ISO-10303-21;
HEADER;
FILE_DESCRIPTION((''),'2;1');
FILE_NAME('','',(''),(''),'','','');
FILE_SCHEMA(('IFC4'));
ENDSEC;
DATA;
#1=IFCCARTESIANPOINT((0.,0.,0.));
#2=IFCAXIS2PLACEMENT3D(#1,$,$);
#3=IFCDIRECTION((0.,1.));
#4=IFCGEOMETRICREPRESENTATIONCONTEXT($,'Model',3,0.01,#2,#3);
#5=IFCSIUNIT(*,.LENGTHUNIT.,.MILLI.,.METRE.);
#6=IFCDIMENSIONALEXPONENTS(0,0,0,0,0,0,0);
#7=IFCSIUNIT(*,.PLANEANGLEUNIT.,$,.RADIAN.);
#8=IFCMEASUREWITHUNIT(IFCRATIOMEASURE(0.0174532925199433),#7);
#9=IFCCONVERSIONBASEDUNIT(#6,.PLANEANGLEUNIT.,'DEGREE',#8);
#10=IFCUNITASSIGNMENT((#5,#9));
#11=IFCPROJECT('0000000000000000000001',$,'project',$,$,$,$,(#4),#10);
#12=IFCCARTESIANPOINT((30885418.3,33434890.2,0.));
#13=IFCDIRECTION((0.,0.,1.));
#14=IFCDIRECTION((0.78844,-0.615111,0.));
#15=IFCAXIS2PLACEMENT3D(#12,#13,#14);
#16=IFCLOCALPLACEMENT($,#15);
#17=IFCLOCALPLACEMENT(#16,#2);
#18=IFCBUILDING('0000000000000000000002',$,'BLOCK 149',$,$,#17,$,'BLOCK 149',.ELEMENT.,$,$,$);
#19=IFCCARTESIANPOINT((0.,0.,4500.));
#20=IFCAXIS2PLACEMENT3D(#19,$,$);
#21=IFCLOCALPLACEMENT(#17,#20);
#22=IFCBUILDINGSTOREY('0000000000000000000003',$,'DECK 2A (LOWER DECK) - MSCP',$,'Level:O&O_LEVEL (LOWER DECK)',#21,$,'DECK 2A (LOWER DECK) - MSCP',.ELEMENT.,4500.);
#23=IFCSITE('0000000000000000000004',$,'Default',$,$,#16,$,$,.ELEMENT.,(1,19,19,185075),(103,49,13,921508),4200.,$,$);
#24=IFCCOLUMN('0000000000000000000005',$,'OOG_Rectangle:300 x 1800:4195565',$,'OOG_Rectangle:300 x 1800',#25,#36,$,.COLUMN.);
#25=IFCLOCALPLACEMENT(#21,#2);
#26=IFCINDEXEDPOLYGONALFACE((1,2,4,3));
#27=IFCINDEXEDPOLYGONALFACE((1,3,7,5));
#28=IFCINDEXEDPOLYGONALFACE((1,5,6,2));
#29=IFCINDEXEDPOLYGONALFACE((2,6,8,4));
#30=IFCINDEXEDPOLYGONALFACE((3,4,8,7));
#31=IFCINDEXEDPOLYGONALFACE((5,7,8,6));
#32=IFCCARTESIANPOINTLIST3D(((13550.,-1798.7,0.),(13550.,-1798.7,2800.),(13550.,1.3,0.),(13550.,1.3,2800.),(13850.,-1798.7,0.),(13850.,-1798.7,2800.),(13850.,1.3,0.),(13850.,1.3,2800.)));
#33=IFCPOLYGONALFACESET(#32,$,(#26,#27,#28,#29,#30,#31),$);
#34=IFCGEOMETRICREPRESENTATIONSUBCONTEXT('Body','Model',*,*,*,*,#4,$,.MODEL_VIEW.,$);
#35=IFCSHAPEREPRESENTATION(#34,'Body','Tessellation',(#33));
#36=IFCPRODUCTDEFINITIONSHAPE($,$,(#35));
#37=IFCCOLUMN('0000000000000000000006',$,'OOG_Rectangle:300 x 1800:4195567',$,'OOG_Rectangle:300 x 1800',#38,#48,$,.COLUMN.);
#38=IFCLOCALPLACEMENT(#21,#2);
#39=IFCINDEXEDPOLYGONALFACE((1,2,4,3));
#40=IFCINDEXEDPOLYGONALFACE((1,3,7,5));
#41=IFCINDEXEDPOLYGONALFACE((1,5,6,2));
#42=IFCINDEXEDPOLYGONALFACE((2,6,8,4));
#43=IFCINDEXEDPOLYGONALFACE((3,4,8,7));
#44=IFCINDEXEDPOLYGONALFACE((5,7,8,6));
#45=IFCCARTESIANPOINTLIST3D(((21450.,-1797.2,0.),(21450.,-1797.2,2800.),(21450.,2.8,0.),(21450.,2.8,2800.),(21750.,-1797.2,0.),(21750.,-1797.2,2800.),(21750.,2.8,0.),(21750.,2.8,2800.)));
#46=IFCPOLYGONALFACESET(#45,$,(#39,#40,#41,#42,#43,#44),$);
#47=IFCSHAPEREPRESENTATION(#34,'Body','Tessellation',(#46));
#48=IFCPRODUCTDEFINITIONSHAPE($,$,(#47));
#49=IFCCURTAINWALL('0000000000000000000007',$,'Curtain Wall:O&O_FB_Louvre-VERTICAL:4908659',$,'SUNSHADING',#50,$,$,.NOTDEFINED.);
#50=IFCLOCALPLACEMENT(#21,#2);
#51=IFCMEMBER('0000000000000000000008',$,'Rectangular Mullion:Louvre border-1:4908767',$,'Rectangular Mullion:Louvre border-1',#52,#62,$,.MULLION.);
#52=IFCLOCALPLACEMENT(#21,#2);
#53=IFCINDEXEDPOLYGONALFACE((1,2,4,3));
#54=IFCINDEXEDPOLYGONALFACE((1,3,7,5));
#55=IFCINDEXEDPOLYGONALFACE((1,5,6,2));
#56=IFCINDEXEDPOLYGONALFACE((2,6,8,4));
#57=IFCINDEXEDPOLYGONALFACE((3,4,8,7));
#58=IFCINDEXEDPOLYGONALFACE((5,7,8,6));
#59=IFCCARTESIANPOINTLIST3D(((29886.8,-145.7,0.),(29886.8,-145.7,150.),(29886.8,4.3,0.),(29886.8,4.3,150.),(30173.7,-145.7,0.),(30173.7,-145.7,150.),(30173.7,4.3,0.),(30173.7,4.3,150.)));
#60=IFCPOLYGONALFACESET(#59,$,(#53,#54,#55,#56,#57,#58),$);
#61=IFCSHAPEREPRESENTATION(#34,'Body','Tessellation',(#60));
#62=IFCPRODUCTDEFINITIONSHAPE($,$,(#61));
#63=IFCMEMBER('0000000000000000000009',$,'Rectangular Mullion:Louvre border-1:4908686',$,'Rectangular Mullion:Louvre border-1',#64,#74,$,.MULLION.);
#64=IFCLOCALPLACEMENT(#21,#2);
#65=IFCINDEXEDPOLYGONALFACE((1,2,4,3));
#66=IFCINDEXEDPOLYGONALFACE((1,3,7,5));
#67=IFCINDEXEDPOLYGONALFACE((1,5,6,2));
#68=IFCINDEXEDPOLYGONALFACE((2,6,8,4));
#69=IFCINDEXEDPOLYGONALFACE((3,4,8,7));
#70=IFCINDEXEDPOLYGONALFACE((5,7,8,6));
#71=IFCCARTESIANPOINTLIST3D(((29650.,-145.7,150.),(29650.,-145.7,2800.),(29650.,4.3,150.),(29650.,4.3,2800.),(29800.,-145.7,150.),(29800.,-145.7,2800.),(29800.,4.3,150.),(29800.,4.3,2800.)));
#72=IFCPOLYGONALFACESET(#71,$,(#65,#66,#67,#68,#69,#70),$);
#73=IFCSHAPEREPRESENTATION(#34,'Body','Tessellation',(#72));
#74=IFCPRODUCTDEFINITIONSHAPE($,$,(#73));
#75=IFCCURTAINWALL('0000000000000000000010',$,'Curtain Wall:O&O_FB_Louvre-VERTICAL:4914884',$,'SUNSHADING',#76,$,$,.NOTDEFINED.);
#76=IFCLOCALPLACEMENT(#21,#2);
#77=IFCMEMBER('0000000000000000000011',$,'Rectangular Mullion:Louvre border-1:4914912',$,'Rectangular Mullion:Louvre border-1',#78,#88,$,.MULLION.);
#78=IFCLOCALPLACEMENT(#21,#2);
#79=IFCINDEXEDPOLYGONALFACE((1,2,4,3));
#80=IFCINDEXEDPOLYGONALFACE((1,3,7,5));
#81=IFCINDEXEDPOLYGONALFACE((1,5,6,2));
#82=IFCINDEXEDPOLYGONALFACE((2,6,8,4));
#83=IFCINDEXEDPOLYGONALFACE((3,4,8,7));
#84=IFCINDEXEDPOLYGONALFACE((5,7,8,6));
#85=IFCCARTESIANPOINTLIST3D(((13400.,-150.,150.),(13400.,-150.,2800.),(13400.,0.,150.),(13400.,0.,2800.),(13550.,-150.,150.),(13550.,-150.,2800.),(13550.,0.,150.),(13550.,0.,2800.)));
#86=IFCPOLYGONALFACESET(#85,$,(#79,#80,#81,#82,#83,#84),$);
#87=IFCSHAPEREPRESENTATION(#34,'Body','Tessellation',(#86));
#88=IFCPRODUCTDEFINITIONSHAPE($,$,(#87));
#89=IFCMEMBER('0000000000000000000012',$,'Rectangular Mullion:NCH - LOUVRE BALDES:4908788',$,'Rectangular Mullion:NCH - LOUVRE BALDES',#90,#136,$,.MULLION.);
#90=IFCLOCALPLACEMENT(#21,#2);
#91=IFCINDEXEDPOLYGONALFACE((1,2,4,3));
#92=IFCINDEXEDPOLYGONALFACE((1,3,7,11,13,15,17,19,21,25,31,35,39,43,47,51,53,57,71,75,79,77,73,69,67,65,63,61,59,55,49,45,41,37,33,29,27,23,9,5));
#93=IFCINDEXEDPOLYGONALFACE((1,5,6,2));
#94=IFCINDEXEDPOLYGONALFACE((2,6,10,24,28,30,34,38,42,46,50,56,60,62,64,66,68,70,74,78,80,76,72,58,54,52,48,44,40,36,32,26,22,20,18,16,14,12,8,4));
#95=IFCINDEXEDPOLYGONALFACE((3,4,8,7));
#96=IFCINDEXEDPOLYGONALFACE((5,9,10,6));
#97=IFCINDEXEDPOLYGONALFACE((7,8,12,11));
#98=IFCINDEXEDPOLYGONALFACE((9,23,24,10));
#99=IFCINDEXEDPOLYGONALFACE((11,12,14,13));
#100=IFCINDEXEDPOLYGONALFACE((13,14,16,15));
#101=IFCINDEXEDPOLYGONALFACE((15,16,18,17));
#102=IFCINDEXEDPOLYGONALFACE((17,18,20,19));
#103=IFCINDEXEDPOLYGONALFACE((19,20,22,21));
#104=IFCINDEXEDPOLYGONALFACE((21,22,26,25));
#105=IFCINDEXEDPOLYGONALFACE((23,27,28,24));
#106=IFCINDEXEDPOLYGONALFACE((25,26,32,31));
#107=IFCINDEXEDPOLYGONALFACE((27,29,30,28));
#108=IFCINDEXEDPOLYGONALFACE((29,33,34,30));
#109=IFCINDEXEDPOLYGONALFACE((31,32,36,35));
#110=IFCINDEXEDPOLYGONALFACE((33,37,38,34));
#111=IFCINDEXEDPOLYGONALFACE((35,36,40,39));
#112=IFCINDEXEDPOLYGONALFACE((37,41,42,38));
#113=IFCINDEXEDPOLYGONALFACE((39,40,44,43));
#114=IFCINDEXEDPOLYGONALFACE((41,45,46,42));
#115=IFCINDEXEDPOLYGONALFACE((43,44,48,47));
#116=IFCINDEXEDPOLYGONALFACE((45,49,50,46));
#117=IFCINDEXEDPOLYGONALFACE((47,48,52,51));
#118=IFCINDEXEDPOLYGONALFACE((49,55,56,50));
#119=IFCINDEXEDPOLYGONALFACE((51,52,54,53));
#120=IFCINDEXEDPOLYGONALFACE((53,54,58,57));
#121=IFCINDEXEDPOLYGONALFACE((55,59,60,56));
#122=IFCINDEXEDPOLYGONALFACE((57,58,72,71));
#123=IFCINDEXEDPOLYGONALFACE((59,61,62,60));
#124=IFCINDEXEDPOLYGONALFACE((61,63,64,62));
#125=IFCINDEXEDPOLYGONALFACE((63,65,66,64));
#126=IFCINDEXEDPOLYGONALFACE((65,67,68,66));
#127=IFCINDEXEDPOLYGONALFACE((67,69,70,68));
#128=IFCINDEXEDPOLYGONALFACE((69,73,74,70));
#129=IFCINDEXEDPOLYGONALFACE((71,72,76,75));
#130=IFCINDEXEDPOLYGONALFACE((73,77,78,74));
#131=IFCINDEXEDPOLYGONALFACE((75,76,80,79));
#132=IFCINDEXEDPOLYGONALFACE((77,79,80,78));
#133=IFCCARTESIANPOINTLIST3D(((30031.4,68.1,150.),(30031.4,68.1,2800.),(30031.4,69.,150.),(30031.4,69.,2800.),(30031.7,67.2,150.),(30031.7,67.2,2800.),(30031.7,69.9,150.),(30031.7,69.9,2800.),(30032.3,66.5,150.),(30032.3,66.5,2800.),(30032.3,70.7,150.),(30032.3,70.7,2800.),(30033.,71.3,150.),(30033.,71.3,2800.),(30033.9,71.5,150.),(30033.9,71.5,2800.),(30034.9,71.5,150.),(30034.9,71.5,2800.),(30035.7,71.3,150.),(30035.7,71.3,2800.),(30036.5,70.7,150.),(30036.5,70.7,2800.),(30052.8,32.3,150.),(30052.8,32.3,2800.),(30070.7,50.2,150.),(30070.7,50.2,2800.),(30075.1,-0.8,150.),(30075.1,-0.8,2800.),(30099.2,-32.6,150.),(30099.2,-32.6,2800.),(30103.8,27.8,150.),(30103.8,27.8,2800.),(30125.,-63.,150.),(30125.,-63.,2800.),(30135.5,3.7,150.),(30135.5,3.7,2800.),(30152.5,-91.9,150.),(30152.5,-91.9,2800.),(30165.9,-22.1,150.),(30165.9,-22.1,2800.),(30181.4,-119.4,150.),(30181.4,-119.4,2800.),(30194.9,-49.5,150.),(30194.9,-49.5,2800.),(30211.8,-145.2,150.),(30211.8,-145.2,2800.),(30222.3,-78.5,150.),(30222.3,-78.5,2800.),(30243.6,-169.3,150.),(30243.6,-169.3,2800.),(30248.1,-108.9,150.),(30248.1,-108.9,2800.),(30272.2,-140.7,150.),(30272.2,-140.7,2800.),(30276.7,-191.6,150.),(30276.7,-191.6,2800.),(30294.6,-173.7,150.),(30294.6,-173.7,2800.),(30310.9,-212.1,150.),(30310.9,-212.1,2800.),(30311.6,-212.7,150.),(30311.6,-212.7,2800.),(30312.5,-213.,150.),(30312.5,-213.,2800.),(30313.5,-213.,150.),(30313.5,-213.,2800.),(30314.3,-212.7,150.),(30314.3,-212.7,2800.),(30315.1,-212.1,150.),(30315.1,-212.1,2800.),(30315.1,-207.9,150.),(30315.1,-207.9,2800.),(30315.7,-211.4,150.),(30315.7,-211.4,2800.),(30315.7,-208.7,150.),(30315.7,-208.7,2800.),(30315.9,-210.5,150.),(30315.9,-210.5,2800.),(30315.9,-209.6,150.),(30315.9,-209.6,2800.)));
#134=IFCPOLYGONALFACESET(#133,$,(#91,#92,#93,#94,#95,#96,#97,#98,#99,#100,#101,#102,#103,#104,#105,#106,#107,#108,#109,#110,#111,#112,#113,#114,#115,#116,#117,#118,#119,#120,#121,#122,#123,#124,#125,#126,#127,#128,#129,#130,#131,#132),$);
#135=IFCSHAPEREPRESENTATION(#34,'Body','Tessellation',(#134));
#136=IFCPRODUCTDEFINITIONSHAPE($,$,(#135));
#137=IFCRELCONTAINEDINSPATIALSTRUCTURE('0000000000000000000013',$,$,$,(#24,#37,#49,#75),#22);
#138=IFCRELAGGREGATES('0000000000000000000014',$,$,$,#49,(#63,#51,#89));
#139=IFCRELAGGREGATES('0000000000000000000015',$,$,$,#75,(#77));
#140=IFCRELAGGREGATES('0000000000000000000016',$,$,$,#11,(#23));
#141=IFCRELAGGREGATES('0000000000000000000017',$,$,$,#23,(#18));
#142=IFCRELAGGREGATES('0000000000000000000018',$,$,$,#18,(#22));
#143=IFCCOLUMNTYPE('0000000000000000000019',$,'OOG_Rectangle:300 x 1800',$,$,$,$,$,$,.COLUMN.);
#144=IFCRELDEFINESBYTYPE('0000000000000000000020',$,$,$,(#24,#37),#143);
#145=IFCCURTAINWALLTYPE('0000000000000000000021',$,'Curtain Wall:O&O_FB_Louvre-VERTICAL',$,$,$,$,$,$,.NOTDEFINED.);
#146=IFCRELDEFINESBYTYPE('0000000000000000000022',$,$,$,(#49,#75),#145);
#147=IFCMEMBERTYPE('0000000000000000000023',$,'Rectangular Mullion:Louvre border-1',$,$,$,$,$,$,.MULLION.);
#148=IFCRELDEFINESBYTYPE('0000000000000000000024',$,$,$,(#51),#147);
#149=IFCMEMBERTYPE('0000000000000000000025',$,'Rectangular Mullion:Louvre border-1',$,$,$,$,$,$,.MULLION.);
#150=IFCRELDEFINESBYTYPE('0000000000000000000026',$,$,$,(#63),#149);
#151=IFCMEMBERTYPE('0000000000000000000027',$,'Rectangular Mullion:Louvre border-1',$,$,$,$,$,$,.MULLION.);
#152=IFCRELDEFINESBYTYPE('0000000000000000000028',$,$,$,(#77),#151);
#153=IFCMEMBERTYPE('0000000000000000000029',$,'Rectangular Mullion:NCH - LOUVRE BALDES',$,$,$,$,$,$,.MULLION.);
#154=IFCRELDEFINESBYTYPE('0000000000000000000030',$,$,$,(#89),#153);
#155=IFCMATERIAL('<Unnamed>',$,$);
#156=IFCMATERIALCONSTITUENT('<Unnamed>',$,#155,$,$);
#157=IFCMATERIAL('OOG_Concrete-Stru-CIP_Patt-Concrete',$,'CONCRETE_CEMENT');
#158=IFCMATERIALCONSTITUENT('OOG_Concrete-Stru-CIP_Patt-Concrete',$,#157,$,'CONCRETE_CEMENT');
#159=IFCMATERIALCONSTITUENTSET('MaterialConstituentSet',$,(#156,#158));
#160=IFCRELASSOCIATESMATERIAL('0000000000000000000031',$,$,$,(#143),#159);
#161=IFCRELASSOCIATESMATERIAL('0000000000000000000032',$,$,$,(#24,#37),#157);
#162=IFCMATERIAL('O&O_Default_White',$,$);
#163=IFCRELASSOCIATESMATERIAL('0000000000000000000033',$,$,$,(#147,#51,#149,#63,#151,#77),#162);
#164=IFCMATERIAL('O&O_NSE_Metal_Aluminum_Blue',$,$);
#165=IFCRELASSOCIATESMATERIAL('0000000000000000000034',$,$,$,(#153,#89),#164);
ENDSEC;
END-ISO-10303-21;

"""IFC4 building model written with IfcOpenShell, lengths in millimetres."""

from ifc_helpers import new_model, entity, si_unit, converted_unit, direction, frame, origin, place, context, subcontext, project, spatial, indexed_curve, outline, extrude, source, transform, mapped, material, constituent, constituent_set, type_object, type_shapes, element, aggregate, save


model = new_model("IFC4")

# Units and contexts
model_context = context("Model", 3, precision=0.01, world=origin(), true_north=direction((0.0, 1.0)))
body_context = subcontext(model_context, "Body", "Model", "MODEL_VIEW")
ifc_project = project(units=[si_unit("LENGTHUNIT", "METRE", prefix="MILLI"), converted_unit("PLANEANGLEUNIT", "DEGREE", entity("IfcRatioMeasure", 0.0174532925199433), si_unit("PLANEANGLEUNIT", "RADIAN"), dimensions=[0, 0, 0, 0, 0, 0, 0])], contexts=[model_context])

# Site, building, storey
site_placement = place(None, frame((30885418.3, 33434890.2, 0.0), z_axis=(0.0, 0.0, 1.0), x_axis=(0.78844, -0.615111, 0.0)))
site = spatial("IfcSite", under=ifc_project, at=site_placement, Name="Default", CompositionType="ELEMENT", RefLatitude=(1, 19, 19, 185075), RefLongitude=(103, 49, 13, 921508), RefElevation=4200.0)
building_placement = place(site_placement, origin())
building = spatial("IfcBuilding", under=site, at=building_placement, Name="BLOCK 149", LongName="BLOCK 149", CompositionType="ELEMENT")
storey_placement = place(building_placement, frame((0.0, 0.0, 4500.0)))
storey = spatial("IfcBuildingStorey", under=building, at=storey_placement, Name="DECK 2A (LOWER DECK) - MSCP", ObjectType="Level:O&O_LEVEL (LOWER DECK)", LongName="DECK 2A (LOWER DECK) - MSCP", CompositionType="ELEMENT", Elevation=4500.0)

# Columns
ifc_material_1 = material(Name="OOG_Concrete-Stru-CIP_Patt-Concrete", Category="CONCRETE_CEMENT")
ifc_material_2 = material(Name="<Unnamed>")
ifc_constituent_1 = constituent(ifc_material_2, Name="<Unnamed>")
ifc_constituent_2 = constituent(ifc_material_1, Name="OOG_Concrete-Stru-CIP_Patt-Concrete", Category="CONCRETE_CEMENT")
ifc_constituent_set = constituent_set(constituents=[ifc_constituent_1, ifc_constituent_2], Name="MaterialConstituentSet")
column_type = type_object("IfcColumnType", Name="OOG_Rectangle:300 x 1800", PredefinedType="COLUMN", material=ifc_constituent_set)
shared_shape_1 = source(origin(), body_context, "Body", "SweptSolid", [
    extrude(outline(indexed_curve([(-900.0, -150.0), (900.0, -150.0), (900.0, 150.0), (-900.0, 150.0), (-900.0, -150.0)], self_intersect=False)), frame((0.0, 0.0, 4500.0), z_axis=(0.0, 0.0, 1.0), x_axis=(0.0, -1.0, 0.0)), (0.0, 0.0, 1.0), 2800.0),
])
type_shapes(column_type, [shared_shape_1])
for number, where, name in (
    (1, (13700.0, -898.7, -4500.0), "OOG_Rectangle:300 x 1800:4195565"),
    (2, (21600.0, -897.2, -4500.0), "OOG_Rectangle:300 x 1800:4195567"),
):
    element("IfcColumn", number, at=place(storey_placement, frame(where)), inside=storey, type_object=column_type, material=ifc_material_1, Name=name, ObjectType="OOG_Rectangle:300 x 1800", PredefinedType="COLUMN", context=body_context, shape_type="MappedRepresentation", body=[
        mapped(shared_shape_1, transform((0.0, 0.0, 0.0), scale=1.0)),
    ])

# Curtain wall, members
curtain_wall_type = type_object("IfcCurtainWallType", Name="Curtain Wall:O&O_FB_Louvre-VERTICAL", PredefinedType="NOTDEFINED")
curtain_wall_1_placement = place(storey_placement, frame((0.0, 0.0, -4500.0)))
curtain_wall_1 = element("IfcCurtainWall", 3, at=curtain_wall_1_placement, inside=storey, type_object=curtain_wall_type, Name="Curtain Wall:O&O_FB_Louvre-VERTICAL:4908659", ObjectType="SUNSHADING", PredefinedType="NOTDEFINED")
ifc_material_3 = material(Name="O&O_Default_White")
member_type_1 = type_object("IfcMemberType", Name="Rectangular Mullion:Louvre border-1", PredefinedType="MULLION", material=ifc_material_3)
shared_shape_2 = source(origin(), body_context, "Body", "SweptSolid", [
    extrude(outline(indexed_curve([(-75.0, -75.0), (75.0, -75.0), (75.0, 75.0), (-75.0, 75.0), (-75.0, -75.0)], self_intersect=False)), frame((-75.0, 0.0, -286.8), z_axis=(0.0, 0.0, 1.0), x_axis=(0.0, -1.0, 0.0)), (0.0, 0.0, 1.0), 286.8),
])
type_shapes(member_type_1, [shared_shape_2])
placement = place(building_placement, origin())
member_1_placement = place(placement, frame((30173.7, -70.7, 4500.0), z_axis=(1.0, 0.0, 0.0), x_axis=(0.0, 0.0, -1.0)))
member_1 = element("IfcMember", 4, at=member_1_placement, type_object=member_type_1, material=ifc_material_3, Name="Rectangular Mullion:Louvre border-1:4908767", ObjectType="Rectangular Mullion:Louvre border-1", PredefinedType="MULLION", context=body_context, shape_type="MappedRepresentation", body=[
    mapped(shared_shape_2, transform((0.0, 0.0, 0.0), scale=1.0)),
])
member_type_2 = type_object("IfcMemberType", Name="Rectangular Mullion:Louvre border-1", PredefinedType="MULLION", material=ifc_material_3)
shared_shape_3 = source(origin(), body_context, "Body", "SweptSolid", [
    extrude(outline(indexed_curve([(-75.0, -75.0), (75.0, -75.0), (75.0, 75.0), (-75.0, 75.0), (-75.0, -75.0)], self_intersect=False)), frame((-75.0, 0.0, -2650.0), z_axis=(0.0, 0.0, 1.0), x_axis=(0.0, -1.0, 0.0)), (0.0, 0.0, 1.0), 2650.0),
])
type_shapes(member_type_2, [shared_shape_3])
member_2_placement = place(placement, frame((29650.0, -70.7, 4650.0), z_axis=(0.0, 0.0, -1.0), x_axis=(-1.0, 0.0, 0.0)))
member_2 = element("IfcMember", 5, at=member_2_placement, type_object=member_type_2, material=ifc_material_3, Name="Rectangular Mullion:Louvre border-1:4908686", ObjectType="Rectangular Mullion:Louvre border-1", PredefinedType="MULLION", context=body_context, shape_type="MappedRepresentation", body=[
    mapped(shared_shape_3, transform((0.0, 0.0, 0.0), scale=1.0)),
])

# Curtain wall, member
curtain_wall_2_placement = place(storey_placement, frame((0.0, 0.0, -4500.0)))
curtain_wall_2 = element("IfcCurtainWall", 6, at=curtain_wall_2_placement, inside=storey, type_object=curtain_wall_type, Name="Curtain Wall:O&O_FB_Louvre-VERTICAL:4914884", ObjectType="SUNSHADING", PredefinedType="NOTDEFINED")
member_type_3 = type_object("IfcMemberType", Name="Rectangular Mullion:Louvre border-1", PredefinedType="MULLION", material=ifc_material_3)
shared_shape_4 = source(origin(), body_context, "Body", "SweptSolid", [
    extrude(outline(indexed_curve([(-75.0, -75.0), (75.0, -75.0), (75.0, 75.0), (-75.0, 75.0), (-75.0, -75.0)], self_intersect=False)), frame((-75.0, 0.0, -2650.0), z_axis=(0.0, 0.0, 1.0), x_axis=(0.0, -1.0, 0.0)), (0.0, 0.0, 1.0), 2650.0),
])
type_shapes(member_type_3, [shared_shape_4])
member_3_placement = place(storey_placement, frame((13550.0, -75.0, 2800.0)))
member_3 = element("IfcMember", 7, at=member_3_placement, type_object=member_type_3, material=ifc_material_3, Name="Rectangular Mullion:Louvre border-1:4914912", ObjectType="Rectangular Mullion:Louvre border-1", PredefinedType="MULLION", context=body_context, shape_type="MappedRepresentation", body=[
    mapped(shared_shape_4, transform((0.0, 0.0, 0.0), scale=1.0)),
])

# Member
ifc_material_4 = material(Name="O&O_NSE_Metal_Aluminum_Blue")
member_type_4 = type_object("IfcMemberType", Name="Rectangular Mullion:NCH - LOUVRE BALDES", PredefinedType="MULLION", material=ifc_material_4)
shared_shape_5 = source(origin(), body_context, "Body", "SweptSolid", [
    extrude(outline(indexed_curve([(55.9, -188.9), (54.8, -149.1), (51.6, -109.3), (46.1, -69.8), (38.6, -30.6), (28.9, 8.1), (17.1, 46.2), (3.3, 83.6), (-12.6, 120.2), (-30.4, 155.9), (-50.1, 190.5), (-50.5, 191.4), (-51.1, 192.1), (-52.0, 192.5), (-52.9, 192.7), (-53.8, 192.6), (-54.7, 192.2), (-55.4, 191.6), (-55.8, 190.8), (-56.0, 189.9), (-55.9, 188.9), (-54.8, 149.1), (-51.6, 109.3), (-46.1, 69.8), (-38.6, 30.6), (-28.9, -8.1), (-17.1, -46.2), (-3.3, -83.6), (12.6, -120.2), (30.4, -155.9), (50.1, -190.5), (50.5, -191.4), (51.1, -192.1), (52.0, -192.5), (52.9, -192.7), (53.8, -192.6), (54.7, -192.2), (55.4, -191.6), (55.8, -190.8), (56.0, -189.9), (55.9, -188.9)], self_intersect=False)), frame((0.0, 0.0, -2650.0), z_axis=(0.0, 0.0, 1.0), x_axis=(0.490779, -0.871284, 0.0)), (0.0, 0.0, 1.0), 2650.0),
])
type_shapes(member_type_4, [shared_shape_5])
member_4_placement = place(placement, frame((30173.7, -70.7, 4650.0), z_axis=(0.0, 0.0, -1.0), x_axis=(-1.0, 0.0, 0.0)))
member_4 = element("IfcMember", 8, at=member_4_placement, type_object=member_type_4, material=ifc_material_4, Name="Rectangular Mullion:NCH - LOUVRE BALDES:4908788", ObjectType="Rectangular Mullion:NCH - LOUVRE BALDES", PredefinedType="MULLION", context=body_context, shape_type="MappedRepresentation", body=[
    mapped(shared_shape_5, transform((0.0, 0.0, 0.0), scale=1.0)),
])
aggregate(curtain_wall_1, [member_2, member_1, member_4])
aggregate(curtain_wall_2, [member_3])

save(model, "model.ifc")
